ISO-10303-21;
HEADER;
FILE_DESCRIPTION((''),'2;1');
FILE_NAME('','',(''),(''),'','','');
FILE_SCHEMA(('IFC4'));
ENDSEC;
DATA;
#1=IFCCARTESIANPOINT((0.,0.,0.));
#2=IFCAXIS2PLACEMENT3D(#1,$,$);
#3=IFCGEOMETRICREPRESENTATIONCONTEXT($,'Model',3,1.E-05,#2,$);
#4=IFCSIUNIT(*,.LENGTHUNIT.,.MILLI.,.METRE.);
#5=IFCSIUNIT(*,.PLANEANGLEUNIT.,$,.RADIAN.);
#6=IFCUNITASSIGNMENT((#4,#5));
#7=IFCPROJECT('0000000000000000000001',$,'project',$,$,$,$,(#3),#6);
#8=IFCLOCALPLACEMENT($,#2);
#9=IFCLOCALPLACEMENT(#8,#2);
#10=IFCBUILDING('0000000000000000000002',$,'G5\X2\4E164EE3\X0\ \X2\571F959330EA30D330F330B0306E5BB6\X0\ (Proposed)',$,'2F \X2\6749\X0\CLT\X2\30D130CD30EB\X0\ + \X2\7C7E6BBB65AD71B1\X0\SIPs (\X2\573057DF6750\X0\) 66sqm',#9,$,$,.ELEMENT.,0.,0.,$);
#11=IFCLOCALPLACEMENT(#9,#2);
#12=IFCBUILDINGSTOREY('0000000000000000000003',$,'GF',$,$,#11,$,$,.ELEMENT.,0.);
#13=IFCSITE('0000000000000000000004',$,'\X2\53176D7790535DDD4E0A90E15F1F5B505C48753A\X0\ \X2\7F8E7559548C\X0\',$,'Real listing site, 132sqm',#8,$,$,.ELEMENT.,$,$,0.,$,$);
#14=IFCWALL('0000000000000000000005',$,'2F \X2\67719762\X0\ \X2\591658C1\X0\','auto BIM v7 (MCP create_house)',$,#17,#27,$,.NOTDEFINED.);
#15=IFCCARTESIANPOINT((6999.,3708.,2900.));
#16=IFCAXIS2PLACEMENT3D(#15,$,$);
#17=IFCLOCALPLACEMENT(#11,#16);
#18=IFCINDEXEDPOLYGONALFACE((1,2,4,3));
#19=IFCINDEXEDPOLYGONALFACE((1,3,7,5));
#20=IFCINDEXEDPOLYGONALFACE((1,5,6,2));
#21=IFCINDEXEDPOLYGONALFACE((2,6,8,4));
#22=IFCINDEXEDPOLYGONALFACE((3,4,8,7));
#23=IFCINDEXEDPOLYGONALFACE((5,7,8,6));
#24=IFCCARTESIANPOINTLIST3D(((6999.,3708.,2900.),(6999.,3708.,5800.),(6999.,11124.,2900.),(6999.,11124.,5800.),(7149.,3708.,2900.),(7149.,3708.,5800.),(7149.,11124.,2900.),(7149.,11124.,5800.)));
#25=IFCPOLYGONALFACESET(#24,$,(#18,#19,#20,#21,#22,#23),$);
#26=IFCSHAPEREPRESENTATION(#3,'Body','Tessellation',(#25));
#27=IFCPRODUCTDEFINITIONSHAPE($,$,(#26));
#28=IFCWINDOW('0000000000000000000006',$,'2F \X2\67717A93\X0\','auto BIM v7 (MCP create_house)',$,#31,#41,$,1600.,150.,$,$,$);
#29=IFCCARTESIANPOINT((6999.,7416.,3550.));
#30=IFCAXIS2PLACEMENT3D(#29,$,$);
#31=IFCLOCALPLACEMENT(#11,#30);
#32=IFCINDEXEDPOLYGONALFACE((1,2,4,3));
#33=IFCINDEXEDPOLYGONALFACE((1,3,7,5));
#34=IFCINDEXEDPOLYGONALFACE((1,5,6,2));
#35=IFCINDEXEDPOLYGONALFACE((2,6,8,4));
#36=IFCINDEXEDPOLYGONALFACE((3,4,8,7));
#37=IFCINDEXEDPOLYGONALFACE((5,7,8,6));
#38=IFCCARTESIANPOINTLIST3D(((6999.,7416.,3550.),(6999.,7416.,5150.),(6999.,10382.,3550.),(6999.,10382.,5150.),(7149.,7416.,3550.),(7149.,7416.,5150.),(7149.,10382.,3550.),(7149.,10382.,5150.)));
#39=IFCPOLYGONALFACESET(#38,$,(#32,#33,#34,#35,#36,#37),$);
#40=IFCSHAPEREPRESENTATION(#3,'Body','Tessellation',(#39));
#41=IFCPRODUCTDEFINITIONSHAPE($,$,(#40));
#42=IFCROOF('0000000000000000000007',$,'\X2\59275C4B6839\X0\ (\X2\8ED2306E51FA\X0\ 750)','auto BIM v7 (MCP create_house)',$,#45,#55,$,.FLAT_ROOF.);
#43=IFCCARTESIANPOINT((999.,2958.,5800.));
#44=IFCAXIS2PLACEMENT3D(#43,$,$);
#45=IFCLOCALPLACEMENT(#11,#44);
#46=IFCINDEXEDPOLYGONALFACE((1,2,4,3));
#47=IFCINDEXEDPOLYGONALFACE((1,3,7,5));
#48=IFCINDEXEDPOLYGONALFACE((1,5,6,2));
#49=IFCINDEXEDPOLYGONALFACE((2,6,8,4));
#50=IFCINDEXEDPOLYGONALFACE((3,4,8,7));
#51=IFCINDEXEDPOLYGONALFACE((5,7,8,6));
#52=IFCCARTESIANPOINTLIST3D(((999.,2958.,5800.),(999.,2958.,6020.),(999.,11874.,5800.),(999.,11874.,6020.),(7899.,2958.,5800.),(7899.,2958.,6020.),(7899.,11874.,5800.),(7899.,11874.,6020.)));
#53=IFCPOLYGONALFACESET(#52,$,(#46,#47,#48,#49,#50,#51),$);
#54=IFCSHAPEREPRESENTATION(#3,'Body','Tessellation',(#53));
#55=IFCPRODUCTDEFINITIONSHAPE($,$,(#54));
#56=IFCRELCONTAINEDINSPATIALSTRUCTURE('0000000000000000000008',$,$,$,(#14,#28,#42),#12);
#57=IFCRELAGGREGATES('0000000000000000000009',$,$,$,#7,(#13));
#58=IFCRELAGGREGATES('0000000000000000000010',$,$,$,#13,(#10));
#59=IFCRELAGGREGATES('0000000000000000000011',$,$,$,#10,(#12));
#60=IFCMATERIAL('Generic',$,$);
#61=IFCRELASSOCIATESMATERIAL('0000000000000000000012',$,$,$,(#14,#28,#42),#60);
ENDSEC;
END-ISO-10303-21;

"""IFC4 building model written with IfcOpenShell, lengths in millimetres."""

from ifc_helpers import new_model, si_unit, frame, frame_2d, origin, place, context, project, spatial, rectangle, extrude, material, element, fill, save


model = new_model("IFC4")

# Units and contexts
model_context = context("Model", 3, precision=1e-05, world=origin())
ifc_project = project(units=[si_unit("LENGTHUNIT", "METRE", prefix="MILLI"), si_unit("PLANEANGLEUNIT", "RADIAN")], contexts=[model_context])

# Site, building, storey
site_placement = place(None, origin())
site = spatial("IfcSite", under=ifc_project, at=site_placement, Name="北海道川上郡弟子屈町 美留和", ObjectType="Real listing site, 132sqm", CompositionType="ELEMENT", RefElevation=0.0)
building_placement = place(site_placement, origin())
building = spatial("IfcBuilding", under=site, at=building_placement, Name="G5世代 土間リビングの家 (Proposed)", ObjectType="2F 杉CLTパネル + 籾殻断熱SIPs (地域材) 66sqm", CompositionType="ELEMENT", ElevationOfRefHeight=0.0, ElevationOfTerrain=0.0)
storey_placement = place(building_placement, origin())
storey = spatial("IfcBuildingStorey", under=building, at=storey_placement, Name="GF", CompositionType="ELEMENT", Elevation=0.0)

# Shared definitions
ifc_material = material(Name="Generic")

# Wall, opening, window
wall_1_placement = place(storey_placement, frame((6999.0, 3708.0, 2900.0)))
wall_1 = element("IfcWall", 1, at=wall_1_placement, inside=storey, material=ifc_material, Name="2F 東面 外壁", Description="auto BIM v7 (MCP create_house)", PredefinedType="NOTDEFINED", context=model_context, shape_type="SweptSolid", body=[
    extrude(rectangle(XDim=150.0, YDim=7416.0, at=frame_2d((75.0, 3708.0))), frame((6999.0, 3708.0, 2900.0)), (0.0, 0.0, 1.0), 2900.0),
])
opening_1_placement = place(storey_placement, frame((6999.0, 7416.0, 3550.0)))
opening_1 = element("IfcOpeningElement", 2, at=opening_1_placement, cuts=wall_1, PredefinedType="NOTDEFINED", context=model_context, shape_type="SweptSolid", body=[
    extrude(rectangle(XDim=150.0, YDim=2966.0, at=frame_2d((75.0, 1483.0))), frame((6999.0, 7416.0, 3550.0)), (0.0, 0.0, 1.0), 1600.0),
])
window_1_placement = place(storey_placement, frame((6999.0, 7416.0, 3550.0)))
window_1 = element("IfcWindow", 3, at=window_1_placement, inside=storey, material=ifc_material, Name="2F 東窓", Description="auto BIM v7 (MCP create_house)", OverallHeight=1600.0, OverallWidth=150.0, context=model_context, shape_type="SweptSolid", body=[
    extrude(rectangle(XDim=150.0, YDim=2966.0, at=frame_2d((75.0, 1483.0))), frame((6999.0, 7416.0, 3550.0)), (0.0, 0.0, 1.0), 1600.0),
])
fill(opening_1, window_1)

# Roof
roof_placement = place(storey_placement, frame((999.0, 2958.0, 5800.0)))
element("IfcRoof", 4, at=roof_placement, inside=storey, material=ifc_material, Name="大屋根 (軒の出 750)", Description="auto BIM v7 (MCP create_house)", PredefinedType="FLAT_ROOF", context=model_context, shape_type="SweptSolid", body=[
    extrude(rectangle(XDim=6900.0, YDim=8916.0, at=frame_2d((3450.0, 4458.0))), frame((999.0, 2958.0, 5800.0)), (0.0, 0.0, 1.0), 220.0),
])

save(model, "model.ifc")
